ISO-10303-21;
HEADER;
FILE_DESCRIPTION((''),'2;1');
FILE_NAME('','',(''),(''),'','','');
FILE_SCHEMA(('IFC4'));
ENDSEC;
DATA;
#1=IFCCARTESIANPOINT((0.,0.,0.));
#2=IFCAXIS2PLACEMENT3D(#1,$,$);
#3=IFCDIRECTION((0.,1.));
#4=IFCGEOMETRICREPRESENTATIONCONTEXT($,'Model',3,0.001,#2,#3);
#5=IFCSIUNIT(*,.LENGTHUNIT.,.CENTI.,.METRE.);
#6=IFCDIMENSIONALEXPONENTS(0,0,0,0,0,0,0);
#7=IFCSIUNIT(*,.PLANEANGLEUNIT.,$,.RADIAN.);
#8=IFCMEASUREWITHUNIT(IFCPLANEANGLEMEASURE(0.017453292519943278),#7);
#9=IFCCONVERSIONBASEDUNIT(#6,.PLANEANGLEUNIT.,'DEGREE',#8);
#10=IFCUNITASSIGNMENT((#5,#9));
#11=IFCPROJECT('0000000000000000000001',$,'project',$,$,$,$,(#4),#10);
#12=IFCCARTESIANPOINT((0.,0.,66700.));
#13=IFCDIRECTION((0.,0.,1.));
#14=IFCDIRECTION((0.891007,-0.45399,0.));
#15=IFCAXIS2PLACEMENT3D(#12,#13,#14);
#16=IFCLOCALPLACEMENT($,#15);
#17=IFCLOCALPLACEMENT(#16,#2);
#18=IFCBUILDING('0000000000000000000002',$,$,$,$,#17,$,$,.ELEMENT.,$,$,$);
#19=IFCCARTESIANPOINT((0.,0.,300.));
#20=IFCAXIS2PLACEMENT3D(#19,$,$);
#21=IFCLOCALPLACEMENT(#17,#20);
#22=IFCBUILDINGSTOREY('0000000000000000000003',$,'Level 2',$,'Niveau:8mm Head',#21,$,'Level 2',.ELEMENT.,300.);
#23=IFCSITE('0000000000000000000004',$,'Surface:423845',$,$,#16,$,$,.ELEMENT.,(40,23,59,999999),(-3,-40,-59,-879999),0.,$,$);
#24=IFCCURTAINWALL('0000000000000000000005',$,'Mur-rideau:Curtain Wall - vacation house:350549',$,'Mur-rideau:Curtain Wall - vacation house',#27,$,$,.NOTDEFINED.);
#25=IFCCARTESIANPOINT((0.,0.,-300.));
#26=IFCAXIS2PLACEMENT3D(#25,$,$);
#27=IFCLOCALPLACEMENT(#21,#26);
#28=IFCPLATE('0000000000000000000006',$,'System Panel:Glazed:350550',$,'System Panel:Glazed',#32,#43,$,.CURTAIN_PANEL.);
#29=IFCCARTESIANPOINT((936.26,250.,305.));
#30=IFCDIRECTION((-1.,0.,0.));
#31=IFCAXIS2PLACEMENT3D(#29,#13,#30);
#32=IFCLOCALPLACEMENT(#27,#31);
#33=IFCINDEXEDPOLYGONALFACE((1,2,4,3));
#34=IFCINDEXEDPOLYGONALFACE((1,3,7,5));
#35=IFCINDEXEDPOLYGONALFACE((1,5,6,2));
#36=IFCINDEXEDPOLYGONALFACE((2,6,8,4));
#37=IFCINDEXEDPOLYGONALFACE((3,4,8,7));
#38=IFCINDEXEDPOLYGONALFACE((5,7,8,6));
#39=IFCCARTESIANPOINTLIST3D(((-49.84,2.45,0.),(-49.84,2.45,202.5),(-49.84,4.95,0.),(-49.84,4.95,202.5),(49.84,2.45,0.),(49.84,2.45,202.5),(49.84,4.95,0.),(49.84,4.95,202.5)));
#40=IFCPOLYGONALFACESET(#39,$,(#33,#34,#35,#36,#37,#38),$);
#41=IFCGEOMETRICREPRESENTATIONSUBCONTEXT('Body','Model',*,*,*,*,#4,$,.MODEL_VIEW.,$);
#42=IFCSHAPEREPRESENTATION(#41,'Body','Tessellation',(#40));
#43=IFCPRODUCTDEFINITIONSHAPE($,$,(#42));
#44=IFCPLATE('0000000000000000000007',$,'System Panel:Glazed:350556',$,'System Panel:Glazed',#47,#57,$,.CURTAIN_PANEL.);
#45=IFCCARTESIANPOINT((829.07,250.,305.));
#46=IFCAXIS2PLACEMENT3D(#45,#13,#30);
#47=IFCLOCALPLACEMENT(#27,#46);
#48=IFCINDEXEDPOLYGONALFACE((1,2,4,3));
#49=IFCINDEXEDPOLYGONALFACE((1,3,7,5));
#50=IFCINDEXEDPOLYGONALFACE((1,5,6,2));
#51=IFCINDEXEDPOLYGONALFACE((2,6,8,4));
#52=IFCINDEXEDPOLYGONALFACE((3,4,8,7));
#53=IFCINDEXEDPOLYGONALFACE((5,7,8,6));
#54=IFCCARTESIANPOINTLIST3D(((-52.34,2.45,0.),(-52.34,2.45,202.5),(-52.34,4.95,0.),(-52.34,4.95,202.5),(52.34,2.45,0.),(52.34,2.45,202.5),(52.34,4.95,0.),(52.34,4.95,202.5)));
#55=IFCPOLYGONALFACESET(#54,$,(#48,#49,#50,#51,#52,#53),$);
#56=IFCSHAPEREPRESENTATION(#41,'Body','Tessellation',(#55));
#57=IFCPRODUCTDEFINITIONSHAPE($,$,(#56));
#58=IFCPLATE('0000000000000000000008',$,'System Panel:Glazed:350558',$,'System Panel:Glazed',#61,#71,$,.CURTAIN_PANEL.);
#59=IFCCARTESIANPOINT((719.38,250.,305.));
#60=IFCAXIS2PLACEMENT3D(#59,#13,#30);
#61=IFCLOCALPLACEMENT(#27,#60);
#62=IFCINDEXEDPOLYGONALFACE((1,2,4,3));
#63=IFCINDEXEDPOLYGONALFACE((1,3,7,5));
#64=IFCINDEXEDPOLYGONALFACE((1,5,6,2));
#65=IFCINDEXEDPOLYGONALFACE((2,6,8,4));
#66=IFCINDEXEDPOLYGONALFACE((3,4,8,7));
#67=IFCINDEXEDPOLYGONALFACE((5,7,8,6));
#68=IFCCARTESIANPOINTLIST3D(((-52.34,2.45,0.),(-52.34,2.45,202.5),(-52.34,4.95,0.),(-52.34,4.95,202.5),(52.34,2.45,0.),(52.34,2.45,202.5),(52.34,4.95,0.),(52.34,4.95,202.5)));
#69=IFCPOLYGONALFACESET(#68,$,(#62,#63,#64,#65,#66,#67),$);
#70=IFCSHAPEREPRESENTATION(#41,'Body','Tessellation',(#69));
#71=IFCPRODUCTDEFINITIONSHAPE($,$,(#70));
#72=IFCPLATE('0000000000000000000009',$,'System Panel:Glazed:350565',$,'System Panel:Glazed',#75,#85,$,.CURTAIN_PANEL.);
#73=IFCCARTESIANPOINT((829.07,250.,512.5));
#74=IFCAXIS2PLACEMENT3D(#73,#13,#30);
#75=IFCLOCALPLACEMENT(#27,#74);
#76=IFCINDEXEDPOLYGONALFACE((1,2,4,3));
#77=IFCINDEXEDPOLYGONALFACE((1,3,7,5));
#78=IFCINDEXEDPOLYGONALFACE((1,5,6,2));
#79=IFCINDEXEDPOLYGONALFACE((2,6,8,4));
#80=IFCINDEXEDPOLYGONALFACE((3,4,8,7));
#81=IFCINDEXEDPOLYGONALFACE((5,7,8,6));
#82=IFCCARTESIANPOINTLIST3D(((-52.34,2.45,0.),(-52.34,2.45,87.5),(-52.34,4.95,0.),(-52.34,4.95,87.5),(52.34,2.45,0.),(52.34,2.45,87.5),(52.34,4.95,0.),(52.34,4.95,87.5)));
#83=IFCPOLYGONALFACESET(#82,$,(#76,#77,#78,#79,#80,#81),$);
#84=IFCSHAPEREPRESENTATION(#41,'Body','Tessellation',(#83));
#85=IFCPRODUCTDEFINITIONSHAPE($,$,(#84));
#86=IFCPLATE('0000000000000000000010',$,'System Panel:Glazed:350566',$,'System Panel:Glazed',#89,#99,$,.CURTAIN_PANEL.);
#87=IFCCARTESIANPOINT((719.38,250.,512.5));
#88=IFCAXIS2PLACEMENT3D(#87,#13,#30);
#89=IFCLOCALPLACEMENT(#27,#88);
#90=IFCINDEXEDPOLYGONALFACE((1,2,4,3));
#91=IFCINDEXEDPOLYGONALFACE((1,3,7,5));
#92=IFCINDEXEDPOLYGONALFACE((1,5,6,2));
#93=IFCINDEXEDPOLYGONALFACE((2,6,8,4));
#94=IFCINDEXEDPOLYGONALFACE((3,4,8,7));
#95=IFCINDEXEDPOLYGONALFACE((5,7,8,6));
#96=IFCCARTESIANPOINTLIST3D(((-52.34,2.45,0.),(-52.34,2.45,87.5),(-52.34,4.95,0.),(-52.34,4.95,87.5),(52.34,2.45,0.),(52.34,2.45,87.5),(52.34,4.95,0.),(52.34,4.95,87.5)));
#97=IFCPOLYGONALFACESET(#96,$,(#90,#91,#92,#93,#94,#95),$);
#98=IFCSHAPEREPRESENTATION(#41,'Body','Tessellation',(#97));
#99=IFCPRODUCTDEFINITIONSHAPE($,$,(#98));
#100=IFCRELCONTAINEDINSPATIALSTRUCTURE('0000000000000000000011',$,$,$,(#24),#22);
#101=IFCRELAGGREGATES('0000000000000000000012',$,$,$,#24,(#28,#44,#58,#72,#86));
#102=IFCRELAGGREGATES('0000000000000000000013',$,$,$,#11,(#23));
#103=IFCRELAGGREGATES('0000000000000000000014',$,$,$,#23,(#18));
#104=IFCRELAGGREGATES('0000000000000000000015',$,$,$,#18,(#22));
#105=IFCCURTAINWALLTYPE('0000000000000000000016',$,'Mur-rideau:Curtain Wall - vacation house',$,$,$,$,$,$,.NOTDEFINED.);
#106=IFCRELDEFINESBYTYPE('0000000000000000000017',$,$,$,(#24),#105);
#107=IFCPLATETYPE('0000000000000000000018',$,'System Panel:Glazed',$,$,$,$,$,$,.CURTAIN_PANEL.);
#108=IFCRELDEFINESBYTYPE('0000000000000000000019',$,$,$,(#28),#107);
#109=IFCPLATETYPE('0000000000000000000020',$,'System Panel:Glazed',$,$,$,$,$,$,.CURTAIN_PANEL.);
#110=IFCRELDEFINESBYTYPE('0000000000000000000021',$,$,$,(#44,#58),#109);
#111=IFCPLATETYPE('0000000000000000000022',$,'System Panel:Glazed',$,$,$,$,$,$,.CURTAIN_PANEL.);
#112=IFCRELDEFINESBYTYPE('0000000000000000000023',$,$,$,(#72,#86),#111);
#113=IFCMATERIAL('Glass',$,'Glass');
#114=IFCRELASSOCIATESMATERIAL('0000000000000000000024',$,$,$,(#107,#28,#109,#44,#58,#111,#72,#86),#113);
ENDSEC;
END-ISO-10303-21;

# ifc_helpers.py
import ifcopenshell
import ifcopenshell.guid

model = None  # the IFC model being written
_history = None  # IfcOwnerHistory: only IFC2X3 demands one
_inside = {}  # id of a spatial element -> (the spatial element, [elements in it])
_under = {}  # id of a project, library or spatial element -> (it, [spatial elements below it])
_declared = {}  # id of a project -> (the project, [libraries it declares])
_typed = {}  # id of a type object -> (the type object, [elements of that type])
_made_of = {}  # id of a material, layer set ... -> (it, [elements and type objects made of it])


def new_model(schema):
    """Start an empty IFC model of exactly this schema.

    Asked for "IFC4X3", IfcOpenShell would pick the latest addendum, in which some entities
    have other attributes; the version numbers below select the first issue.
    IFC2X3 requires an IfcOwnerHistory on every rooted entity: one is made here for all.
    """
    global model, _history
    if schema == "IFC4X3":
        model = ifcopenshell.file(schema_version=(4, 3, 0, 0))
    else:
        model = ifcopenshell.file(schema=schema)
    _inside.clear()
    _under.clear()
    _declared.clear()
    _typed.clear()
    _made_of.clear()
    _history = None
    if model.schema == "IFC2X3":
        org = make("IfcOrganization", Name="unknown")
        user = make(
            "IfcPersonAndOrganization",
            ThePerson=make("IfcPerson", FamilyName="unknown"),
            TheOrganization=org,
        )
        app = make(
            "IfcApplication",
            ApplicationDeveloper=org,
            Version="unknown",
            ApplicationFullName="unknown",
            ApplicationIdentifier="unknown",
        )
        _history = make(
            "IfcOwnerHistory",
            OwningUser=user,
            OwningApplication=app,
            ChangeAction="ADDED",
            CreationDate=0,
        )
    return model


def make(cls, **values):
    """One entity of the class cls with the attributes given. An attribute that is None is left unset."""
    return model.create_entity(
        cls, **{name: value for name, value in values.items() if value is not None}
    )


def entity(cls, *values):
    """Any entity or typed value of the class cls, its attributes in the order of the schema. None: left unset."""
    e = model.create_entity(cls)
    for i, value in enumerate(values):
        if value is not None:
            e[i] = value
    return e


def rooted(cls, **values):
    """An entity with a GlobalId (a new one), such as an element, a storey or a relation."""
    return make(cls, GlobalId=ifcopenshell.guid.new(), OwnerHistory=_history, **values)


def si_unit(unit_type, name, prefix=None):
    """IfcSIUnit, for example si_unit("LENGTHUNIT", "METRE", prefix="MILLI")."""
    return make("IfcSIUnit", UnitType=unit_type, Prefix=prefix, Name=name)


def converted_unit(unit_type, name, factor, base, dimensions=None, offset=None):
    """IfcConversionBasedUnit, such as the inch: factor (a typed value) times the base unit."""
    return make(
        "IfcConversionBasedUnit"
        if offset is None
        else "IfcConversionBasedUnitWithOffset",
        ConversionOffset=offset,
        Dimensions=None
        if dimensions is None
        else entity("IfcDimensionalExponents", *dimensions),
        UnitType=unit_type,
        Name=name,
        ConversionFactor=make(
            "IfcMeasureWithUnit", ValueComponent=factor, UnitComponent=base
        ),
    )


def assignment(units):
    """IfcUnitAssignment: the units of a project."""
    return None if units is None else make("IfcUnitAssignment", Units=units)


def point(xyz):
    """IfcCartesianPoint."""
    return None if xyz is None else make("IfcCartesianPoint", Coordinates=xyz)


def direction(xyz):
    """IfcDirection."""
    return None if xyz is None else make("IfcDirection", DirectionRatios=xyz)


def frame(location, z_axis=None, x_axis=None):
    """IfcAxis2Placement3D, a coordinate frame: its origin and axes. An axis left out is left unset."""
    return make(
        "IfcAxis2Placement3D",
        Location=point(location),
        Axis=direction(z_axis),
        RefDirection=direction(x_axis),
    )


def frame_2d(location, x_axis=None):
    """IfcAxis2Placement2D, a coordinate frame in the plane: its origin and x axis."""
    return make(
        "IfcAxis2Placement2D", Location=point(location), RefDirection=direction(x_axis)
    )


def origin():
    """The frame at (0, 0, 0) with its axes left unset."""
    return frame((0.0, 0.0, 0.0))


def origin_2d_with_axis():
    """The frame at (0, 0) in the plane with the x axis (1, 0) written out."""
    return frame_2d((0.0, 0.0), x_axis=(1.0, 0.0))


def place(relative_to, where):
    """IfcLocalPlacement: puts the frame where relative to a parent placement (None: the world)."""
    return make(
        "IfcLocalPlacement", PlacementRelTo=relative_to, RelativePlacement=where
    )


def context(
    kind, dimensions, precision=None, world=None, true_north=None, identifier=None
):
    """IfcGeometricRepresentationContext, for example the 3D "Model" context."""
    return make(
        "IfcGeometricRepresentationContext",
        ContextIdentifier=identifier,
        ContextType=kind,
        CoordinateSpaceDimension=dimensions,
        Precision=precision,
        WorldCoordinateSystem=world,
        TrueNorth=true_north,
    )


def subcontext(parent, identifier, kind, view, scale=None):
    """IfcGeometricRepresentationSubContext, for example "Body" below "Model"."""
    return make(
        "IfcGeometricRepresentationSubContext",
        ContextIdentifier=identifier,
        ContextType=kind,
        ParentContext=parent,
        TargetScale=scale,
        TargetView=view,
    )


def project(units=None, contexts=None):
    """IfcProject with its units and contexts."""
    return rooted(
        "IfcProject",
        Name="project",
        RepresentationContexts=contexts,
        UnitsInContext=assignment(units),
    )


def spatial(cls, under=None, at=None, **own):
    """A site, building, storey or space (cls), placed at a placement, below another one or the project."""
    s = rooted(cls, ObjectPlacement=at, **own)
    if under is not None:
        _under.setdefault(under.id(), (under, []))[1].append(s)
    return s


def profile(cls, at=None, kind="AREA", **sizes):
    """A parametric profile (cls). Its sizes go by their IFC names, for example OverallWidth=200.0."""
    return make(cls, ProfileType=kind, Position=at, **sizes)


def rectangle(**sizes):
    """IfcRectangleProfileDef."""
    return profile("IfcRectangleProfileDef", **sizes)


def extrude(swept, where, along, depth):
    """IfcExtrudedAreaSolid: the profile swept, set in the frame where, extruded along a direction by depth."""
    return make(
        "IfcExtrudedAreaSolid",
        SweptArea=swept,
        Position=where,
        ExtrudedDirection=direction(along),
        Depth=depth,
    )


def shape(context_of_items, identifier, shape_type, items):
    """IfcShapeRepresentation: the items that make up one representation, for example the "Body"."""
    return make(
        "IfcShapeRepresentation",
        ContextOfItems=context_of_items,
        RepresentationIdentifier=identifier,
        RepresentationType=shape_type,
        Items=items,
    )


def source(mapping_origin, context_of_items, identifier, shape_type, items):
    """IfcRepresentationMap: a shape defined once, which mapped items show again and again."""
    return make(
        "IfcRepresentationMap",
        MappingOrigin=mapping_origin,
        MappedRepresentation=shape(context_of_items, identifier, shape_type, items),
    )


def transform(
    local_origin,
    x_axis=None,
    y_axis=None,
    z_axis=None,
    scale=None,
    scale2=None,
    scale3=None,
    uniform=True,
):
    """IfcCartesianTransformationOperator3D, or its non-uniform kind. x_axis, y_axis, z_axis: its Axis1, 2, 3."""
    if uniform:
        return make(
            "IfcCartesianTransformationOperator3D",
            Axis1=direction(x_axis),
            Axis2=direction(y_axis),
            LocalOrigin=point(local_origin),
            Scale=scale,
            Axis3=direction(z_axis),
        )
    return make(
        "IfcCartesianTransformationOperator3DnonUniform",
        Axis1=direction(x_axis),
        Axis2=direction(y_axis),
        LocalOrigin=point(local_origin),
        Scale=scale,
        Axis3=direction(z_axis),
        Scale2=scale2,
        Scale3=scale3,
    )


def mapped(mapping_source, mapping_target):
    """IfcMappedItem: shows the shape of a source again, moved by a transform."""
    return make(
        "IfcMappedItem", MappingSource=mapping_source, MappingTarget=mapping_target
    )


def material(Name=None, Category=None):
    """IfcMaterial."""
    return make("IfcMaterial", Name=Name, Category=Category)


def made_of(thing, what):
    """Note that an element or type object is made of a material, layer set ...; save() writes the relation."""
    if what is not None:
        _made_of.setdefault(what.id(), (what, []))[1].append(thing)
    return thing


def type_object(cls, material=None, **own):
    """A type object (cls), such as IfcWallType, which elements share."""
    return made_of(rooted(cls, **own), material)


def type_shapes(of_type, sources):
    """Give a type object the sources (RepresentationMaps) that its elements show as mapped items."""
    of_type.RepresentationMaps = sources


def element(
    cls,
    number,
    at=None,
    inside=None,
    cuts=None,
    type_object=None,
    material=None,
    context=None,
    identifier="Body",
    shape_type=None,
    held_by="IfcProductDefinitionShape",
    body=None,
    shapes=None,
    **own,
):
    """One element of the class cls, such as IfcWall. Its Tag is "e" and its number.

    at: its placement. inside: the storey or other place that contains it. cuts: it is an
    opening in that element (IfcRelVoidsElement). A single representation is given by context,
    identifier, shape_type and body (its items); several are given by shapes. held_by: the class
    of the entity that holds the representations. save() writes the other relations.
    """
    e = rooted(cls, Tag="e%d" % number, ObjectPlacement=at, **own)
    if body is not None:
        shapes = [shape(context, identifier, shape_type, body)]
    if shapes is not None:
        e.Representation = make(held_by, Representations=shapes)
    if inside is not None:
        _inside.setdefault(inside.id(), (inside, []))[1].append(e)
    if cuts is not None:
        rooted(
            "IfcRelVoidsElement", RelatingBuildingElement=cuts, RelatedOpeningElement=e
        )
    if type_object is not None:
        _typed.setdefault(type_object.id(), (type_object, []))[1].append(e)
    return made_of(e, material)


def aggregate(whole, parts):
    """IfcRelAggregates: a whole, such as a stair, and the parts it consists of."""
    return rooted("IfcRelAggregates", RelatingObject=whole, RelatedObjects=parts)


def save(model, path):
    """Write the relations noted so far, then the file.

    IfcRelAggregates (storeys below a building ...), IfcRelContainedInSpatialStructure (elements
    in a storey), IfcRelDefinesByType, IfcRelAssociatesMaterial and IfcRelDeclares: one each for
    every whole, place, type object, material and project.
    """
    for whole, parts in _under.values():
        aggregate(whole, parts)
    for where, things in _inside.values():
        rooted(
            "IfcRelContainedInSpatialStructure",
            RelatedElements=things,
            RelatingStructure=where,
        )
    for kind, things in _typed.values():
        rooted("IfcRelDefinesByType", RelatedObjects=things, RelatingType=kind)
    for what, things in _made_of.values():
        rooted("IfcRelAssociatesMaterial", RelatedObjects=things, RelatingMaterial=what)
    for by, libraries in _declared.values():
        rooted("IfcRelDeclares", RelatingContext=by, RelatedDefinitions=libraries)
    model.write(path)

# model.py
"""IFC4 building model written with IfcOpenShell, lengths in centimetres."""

from ifc_helpers import new_model, entity, si_unit, converted_unit, direction, frame, origin, origin_2d_with_axis, place, context, subcontext, project, spatial, rectangle, extrude, source, transform, mapped, material, type_object, type_shapes, element, aggregate, save


model = new_model("IFC4")

# Units and contexts
model_context = context("Model", 3, precision=0.001, world=origin(), true_north=direction((0.0, 1.0)))
body_context = subcontext(model_context, "Body", "Model", "MODEL_VIEW")
ifc_project = project(units=[si_unit("LENGTHUNIT", "METRE", prefix="CENTI"), converted_unit("PLANEANGLEUNIT", "DEGREE", entity("IfcPlaneAngleMeasure", 0.017453292519943278), si_unit("PLANEANGLEUNIT", "RADIAN"), dimensions=[0, 0, 0, 0, 0, 0, 0])], contexts=[model_context])

# Site, building, storey
site_placement = place(None, frame((0.0, 0.0, 66700.0), z_axis=(0.0, 0.0, 1.0), x_axis=(0.891007, -0.45399, 0.0)))
site = spatial("IfcSite", under=ifc_project, at=site_placement, Name="Surface:423845", CompositionType="ELEMENT", RefLatitude=(40, 23, 59, 999999), RefLongitude=(-3, -40, -59, -879999), RefElevation=0.0)
building_placement = place(site_placement, origin())
building = spatial("IfcBuilding", under=site, at=building_placement, CompositionType="ELEMENT")
storey_placement = place(building_placement, frame((0.0, 0.0, 300.0)))
storey = spatial("IfcBuildingStorey", under=building, at=storey_placement, Name="Level 2", ObjectType="Niveau:8mm Head", LongName="Level 2", CompositionType="ELEMENT", Elevation=300.0)

# Curtain wall, plates
curtain_wall_type = type_object("IfcCurtainWallType", Name="Mur-rideau:Curtain Wall - vacation house", PredefinedType="NOTDEFINED")
curtain_wall_placement = place(storey_placement, frame((0.0, 0.0, -300.0)))
curtain_wall = element("IfcCurtainWall", 1, at=curtain_wall_placement, inside=storey, type_object=curtain_wall_type, Name="Mur-rideau:Curtain Wall - vacation house:350549", ObjectType="Mur-rideau:Curtain Wall - vacation house", PredefinedType="NOTDEFINED")
ifc_material_1 = material(Name="Glass", Category="Glass")
plate_type_1 = type_object("IfcPlateType", Name="System Panel:Glazed", PredefinedType="CURTAIN_PANEL", material=ifc_material_1)
shared_shape_1 = source(origin(), body_context, "Body", "SweptSolid", [
    extrude(rectangle(XDim=2.5, YDim=99.69, at=origin_2d_with_axis()), frame((0.0, 3.7, 0.0), z_axis=(0.0, 0.0, 1.0), x_axis=(0.0, 1.0, 0.0)), (0.0, 0.0, 1.0), 202.5),
])
type_shapes(plate_type_1, [shared_shape_1])
plate_1_placement = place(curtain_wall_placement, frame((936.26, 250.0, 305.0), z_axis=(0.0, 0.0, 1.0), x_axis=(-1.0, 0.0, 0.0)))
plate_1 = element("IfcPlate", 2, at=plate_1_placement, type_object=plate_type_1, material=ifc_material_1, Name="System Panel:Glazed:350550", ObjectType="System Panel:Glazed", PredefinedType="CURTAIN_PANEL", context=body_context, shape_type="MappedRepresentation", body=[
    mapped(shared_shape_1, transform((0.0, 0.0, 0.0), scale=1.0)),
])
plate_type_2 = type_object("IfcPlateType", Name="System Panel:Glazed", PredefinedType="CURTAIN_PANEL", material=ifc_material_1)
shared_shape_2 = source(origin(), body_context, "Body", "SweptSolid", [
    extrude(rectangle(XDim=2.5, YDim=104.69, at=origin_2d_with_axis()), frame((0.0, 3.7, 0.0), z_axis=(0.0, 0.0, 1.0), x_axis=(0.0, 1.0, 0.0)), (0.0, 0.0, 1.0), 202.5),
])
type_shapes(plate_type_2, [shared_shape_2])
plate_2_placement = place(curtain_wall_placement, frame((829.07, 250.0, 305.0), z_axis=(0.0, 0.0, 1.0), x_axis=(-1.0, 0.0, 0.0)))
plate_2 = element("IfcPlate", 3, at=plate_2_placement, type_object=plate_type_2, material=ifc_material_1, Name="System Panel:Glazed:350556", ObjectType="System Panel:Glazed", PredefinedType="CURTAIN_PANEL", context=body_context, shape_type="MappedRepresentation", body=[
    mapped(shared_shape_2, transform((0.0, 0.0, 0.0), scale=1.0)),
])
plate_3_placement = place(curtain_wall_placement, frame((719.38, 250.0, 305.0), z_axis=(0.0, 0.0, 1.0), x_axis=(-1.0, 0.0, 0.0)))
plate_3 = element("IfcPlate", 4, at=plate_3_placement, type_object=plate_type_2, material=ifc_material_1, Name="System Panel:Glazed:350558", ObjectType="System Panel:Glazed", PredefinedType="CURTAIN_PANEL", context=body_context, shape_type="MappedRepresentation", body=[
    mapped(shared_shape_2, transform((0.0, 0.0, 0.0), scale=1.0)),
])
plate_type_3 = type_object("IfcPlateType", Name="System Panel:Glazed", PredefinedType="CURTAIN_PANEL", material=ifc_material_1)
shared_shape_3 = source(origin(), body_context, "Body", "SweptSolid", [
    extrude(rectangle(XDim=2.5, YDim=104.69, at=origin_2d_with_axis()), frame((0.0, 3.7, 0.0), z_axis=(0.0, 0.0, 1.0), x_axis=(0.0, 1.0, 0.0)), (0.0, 0.0, 1.0), 87.5),
])
type_shapes(plate_type_3, [shared_shape_3])
plate_4_placement = place(curtain_wall_placement, frame((829.07, 250.0, 512.5), z_axis=(0.0, 0.0, 1.0), x_axis=(-1.0, 0.0, 0.0)))
plate_4 = element("IfcPlate", 5, at=plate_4_placement, type_object=plate_type_3, material=ifc_material_1, Name="System Panel:Glazed:350565", ObjectType="System Panel:Glazed", PredefinedType="CURTAIN_PANEL", context=body_context, shape_type="MappedRepresentation", body=[
    mapped(shared_shape_3, transform((0.0, 0.0, 0.0), scale=1.0)),
])
plate_5_placement = place(curtain_wall_placement, frame((719.38, 250.0, 512.5), z_axis=(0.0, 0.0, 1.0), x_axis=(-1.0, 0.0, 0.0)))
plate_5 = element("IfcPlate", 6, at=plate_5_placement, type_object=plate_type_3, material=ifc_material_1, Name="System Panel:Glazed:350566", ObjectType="System Panel:Glazed", PredefinedType="CURTAIN_PANEL", context=body_context, shape_type="MappedRepresentation", body=[
    mapped(shared_shape_3, transform((0.0, 0.0, 0.0), scale=1.0)),
])
aggregate(curtain_wall, [plate_1, plate_2, plate_3, plate_4, plate_5])

save(model, "model.ifc")
